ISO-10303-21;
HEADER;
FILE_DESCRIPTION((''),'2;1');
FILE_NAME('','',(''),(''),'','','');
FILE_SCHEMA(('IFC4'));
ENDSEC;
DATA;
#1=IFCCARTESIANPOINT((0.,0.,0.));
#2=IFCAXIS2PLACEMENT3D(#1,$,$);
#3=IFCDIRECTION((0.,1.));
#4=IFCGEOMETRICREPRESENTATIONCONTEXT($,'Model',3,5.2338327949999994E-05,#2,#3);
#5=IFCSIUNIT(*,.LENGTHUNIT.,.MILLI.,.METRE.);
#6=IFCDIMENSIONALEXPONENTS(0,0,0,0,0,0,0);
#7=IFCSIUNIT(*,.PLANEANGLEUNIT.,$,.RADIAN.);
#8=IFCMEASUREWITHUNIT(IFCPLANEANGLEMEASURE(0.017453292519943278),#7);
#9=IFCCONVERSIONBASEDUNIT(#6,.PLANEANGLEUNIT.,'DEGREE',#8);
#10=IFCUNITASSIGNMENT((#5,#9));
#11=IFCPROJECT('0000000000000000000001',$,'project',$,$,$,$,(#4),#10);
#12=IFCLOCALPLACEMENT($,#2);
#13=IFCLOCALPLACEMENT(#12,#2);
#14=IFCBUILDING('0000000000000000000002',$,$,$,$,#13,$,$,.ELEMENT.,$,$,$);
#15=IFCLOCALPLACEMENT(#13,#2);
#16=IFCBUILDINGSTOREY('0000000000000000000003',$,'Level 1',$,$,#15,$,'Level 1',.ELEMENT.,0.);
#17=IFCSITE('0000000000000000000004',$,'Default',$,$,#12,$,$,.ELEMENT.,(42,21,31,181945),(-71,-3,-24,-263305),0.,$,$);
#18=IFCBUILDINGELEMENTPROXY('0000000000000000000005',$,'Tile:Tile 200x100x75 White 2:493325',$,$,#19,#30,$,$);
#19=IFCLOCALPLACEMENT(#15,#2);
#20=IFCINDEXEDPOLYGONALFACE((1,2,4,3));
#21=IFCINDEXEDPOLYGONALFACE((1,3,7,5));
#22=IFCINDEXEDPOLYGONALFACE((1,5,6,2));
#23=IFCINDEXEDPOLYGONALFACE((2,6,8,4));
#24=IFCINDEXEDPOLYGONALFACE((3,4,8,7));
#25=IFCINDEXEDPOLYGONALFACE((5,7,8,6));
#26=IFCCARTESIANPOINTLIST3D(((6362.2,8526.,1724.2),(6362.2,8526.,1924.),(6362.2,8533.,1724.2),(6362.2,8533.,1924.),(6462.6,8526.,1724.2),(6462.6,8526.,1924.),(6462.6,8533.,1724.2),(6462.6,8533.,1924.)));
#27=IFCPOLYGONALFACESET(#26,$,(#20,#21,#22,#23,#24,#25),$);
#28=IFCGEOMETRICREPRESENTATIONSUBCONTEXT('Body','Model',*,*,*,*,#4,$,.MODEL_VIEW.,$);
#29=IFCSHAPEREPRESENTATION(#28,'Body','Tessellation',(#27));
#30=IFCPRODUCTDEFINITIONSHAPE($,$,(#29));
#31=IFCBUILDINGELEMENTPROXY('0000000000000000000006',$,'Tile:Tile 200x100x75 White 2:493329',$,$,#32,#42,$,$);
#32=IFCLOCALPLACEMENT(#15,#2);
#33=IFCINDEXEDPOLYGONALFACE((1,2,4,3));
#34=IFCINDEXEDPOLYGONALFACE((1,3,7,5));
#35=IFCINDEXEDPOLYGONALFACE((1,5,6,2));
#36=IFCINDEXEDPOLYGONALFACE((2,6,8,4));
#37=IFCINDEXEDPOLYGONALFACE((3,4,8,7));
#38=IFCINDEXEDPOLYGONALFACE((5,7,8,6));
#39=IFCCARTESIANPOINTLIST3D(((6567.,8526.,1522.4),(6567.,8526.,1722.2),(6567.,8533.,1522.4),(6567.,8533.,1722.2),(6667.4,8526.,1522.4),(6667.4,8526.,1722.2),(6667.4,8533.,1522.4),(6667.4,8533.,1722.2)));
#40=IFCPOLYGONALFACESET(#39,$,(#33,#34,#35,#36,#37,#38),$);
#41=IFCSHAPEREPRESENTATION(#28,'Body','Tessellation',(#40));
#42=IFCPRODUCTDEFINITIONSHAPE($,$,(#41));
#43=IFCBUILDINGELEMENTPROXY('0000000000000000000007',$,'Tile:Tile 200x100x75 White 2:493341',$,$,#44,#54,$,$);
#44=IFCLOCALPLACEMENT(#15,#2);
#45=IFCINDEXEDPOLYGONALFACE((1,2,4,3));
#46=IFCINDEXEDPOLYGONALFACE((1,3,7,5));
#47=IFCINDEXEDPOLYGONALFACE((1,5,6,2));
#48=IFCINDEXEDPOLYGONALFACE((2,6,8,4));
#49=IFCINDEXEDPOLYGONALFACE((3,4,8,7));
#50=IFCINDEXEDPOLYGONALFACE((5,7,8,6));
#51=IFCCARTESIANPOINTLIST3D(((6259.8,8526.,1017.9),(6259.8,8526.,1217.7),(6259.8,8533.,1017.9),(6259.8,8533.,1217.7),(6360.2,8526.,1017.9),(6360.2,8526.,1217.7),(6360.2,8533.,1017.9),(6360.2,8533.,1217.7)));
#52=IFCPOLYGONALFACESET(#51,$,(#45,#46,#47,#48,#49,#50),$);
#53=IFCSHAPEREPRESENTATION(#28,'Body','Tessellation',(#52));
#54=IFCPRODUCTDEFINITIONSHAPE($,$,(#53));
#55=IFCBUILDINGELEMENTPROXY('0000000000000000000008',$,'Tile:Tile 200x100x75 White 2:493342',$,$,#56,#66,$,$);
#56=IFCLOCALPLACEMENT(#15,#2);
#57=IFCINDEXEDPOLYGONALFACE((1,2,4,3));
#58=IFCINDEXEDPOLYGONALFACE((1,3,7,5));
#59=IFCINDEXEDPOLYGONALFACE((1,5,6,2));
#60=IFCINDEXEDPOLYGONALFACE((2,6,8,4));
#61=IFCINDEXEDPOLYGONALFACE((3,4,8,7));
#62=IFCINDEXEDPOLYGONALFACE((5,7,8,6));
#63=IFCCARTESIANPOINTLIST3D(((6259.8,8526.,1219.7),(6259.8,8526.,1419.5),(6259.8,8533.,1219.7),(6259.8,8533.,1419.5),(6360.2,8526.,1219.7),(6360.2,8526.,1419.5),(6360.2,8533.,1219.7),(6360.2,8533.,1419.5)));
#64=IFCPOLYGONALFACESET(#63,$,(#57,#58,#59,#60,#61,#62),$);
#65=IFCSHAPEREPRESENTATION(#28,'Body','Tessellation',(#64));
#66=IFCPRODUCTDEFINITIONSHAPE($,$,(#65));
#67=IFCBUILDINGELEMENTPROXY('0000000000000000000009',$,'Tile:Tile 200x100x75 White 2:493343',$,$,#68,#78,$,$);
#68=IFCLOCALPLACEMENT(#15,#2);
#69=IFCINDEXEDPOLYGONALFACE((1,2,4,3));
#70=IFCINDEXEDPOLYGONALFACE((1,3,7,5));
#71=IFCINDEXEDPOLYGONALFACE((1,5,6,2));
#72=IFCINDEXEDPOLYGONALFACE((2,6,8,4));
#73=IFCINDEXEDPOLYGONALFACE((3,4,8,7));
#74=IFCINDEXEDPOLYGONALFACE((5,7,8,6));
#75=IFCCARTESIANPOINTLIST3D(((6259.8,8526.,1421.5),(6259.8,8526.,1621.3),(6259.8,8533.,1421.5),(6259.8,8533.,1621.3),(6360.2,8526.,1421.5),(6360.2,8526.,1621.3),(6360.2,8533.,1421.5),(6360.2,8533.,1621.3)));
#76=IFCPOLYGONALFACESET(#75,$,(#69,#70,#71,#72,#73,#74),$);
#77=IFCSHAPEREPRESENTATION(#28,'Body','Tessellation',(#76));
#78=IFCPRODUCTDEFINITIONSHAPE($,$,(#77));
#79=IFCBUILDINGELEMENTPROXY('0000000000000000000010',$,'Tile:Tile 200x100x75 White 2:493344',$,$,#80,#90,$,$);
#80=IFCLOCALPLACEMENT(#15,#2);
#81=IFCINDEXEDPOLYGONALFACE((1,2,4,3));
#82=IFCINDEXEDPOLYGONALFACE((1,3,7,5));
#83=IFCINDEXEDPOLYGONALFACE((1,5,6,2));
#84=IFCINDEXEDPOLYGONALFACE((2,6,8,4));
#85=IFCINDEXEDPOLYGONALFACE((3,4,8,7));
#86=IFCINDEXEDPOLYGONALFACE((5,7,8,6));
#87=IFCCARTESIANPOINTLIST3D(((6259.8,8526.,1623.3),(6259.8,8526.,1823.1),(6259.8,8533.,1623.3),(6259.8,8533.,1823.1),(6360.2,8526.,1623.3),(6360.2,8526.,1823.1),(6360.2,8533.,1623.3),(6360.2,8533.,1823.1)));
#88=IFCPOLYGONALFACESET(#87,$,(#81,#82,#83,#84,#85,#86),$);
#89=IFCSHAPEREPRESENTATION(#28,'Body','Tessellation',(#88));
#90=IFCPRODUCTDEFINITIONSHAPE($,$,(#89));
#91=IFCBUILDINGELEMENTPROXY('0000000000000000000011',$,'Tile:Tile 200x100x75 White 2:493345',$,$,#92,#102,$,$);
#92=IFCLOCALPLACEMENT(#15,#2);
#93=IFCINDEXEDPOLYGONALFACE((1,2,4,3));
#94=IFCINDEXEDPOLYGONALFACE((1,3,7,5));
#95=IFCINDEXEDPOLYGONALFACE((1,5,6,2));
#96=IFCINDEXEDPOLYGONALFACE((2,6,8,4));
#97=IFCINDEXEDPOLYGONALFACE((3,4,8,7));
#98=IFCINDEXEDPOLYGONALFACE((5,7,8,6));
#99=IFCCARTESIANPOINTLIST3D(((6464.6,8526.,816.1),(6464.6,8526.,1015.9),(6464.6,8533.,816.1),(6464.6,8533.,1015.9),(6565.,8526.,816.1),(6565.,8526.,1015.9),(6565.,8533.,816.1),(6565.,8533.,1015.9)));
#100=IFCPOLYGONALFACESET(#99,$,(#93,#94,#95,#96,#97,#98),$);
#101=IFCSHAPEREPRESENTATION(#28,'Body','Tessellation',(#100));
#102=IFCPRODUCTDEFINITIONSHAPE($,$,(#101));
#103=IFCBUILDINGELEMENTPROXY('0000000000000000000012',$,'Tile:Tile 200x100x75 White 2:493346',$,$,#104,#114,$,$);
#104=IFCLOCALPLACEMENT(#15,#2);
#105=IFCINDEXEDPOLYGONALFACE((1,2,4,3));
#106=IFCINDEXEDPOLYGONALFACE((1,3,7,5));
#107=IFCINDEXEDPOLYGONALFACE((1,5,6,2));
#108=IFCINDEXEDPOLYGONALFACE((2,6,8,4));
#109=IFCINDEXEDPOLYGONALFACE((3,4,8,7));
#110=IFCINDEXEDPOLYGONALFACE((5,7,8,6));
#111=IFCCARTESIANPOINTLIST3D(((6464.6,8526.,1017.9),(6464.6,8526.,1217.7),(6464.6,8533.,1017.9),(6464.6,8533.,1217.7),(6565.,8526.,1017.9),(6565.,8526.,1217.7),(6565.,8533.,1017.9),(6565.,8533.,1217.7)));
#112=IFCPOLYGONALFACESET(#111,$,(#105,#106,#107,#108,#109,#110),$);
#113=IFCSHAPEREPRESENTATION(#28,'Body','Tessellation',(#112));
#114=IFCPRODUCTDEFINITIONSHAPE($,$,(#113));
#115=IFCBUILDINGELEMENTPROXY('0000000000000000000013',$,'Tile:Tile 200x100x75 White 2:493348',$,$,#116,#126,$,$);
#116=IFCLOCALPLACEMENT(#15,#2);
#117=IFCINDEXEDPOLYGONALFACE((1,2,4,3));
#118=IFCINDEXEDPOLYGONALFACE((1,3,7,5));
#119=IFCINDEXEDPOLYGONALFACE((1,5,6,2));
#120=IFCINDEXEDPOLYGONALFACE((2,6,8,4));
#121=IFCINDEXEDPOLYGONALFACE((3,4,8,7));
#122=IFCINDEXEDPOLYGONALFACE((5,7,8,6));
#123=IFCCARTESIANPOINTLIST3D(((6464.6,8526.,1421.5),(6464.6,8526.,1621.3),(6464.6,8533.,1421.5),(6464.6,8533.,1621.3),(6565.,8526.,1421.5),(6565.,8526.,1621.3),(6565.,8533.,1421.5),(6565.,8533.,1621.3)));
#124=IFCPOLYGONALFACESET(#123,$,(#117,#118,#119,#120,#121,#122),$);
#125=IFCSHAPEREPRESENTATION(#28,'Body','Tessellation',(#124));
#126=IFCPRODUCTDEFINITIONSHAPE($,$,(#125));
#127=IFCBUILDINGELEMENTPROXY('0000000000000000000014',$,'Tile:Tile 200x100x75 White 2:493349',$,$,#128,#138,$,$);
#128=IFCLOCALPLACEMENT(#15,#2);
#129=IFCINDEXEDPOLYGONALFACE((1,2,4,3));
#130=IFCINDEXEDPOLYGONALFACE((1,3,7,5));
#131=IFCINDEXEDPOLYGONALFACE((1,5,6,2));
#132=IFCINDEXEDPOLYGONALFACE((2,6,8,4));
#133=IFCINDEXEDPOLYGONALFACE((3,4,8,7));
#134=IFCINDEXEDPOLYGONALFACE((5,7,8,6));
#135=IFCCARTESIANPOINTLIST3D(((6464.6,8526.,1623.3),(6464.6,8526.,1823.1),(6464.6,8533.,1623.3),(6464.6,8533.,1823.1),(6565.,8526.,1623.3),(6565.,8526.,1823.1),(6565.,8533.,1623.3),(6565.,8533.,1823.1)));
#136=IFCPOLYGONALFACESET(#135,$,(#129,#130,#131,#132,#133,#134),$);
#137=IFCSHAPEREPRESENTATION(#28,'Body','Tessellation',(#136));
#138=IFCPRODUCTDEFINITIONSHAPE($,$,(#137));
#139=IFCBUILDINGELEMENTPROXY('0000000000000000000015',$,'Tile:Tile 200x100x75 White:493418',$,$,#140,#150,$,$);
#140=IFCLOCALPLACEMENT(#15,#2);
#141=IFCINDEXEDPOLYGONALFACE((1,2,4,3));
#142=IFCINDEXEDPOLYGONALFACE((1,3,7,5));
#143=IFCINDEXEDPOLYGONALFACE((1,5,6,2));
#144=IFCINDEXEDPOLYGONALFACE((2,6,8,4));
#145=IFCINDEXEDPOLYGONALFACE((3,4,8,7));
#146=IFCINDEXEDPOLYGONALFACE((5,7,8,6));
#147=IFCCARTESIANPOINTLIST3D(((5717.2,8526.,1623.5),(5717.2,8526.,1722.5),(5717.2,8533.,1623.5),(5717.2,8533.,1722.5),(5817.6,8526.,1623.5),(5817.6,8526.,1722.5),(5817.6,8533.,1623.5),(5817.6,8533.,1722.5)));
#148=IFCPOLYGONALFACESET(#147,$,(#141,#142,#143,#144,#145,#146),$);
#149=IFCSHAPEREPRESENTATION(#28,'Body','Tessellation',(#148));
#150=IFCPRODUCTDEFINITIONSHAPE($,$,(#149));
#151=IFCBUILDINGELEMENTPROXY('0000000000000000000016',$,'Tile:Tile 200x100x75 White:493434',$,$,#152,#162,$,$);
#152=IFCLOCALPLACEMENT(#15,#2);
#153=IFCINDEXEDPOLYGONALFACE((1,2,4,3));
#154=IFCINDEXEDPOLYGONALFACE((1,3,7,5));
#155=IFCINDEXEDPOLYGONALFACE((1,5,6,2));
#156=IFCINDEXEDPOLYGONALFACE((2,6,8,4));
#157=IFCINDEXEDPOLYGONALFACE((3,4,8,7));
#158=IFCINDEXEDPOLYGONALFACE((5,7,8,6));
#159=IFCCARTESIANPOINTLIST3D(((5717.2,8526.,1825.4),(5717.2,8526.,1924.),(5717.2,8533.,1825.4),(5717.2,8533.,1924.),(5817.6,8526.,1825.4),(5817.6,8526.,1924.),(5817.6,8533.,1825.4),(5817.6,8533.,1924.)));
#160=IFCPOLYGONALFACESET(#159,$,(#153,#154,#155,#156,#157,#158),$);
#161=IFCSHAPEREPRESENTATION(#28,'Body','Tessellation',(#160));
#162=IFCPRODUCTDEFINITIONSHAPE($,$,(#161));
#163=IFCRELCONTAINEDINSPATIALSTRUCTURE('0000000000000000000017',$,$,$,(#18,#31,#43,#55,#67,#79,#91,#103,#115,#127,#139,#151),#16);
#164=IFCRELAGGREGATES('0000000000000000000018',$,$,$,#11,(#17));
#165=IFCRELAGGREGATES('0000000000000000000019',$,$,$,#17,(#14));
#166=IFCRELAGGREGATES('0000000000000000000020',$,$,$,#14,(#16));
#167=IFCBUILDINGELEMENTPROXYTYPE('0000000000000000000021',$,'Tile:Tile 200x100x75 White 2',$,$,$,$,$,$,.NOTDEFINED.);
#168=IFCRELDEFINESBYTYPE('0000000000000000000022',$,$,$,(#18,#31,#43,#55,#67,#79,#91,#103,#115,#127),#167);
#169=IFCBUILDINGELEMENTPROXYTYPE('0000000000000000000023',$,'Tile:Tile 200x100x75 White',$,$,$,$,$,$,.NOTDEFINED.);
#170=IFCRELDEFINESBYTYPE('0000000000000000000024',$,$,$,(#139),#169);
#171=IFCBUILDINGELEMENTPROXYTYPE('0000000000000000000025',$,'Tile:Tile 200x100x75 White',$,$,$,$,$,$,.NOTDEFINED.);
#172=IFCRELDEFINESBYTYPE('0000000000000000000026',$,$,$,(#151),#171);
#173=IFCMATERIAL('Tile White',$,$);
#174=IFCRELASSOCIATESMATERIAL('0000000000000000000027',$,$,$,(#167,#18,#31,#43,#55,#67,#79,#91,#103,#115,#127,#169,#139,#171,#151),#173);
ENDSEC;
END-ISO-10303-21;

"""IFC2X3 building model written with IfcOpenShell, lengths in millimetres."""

from ifc_helpers import new_model, entity, si_unit, converted_unit, direction, frame, frame_2d, origin, origin_2d_with_axis, place, context, subcontext, project, spatial, rectangle, extrude, source, transform, mapped, material, type_object, type_shapes, element, save


model = new_model("IFC2X3")

# Units and contexts
model_context = context("Model", 3, precision=5.2338327949999994e-05, world=origin(), true_north=direction((0.0, 1.0)))
body_context = subcontext(model_context, "Body", "Model", "MODEL_VIEW")
ifc_project = project(units=[si_unit("LENGTHUNIT", "METRE", prefix="MILLI"), converted_unit("PLANEANGLEUNIT", "DEGREE", entity("IfcPlaneAngleMeasure", 0.017453292519943278), si_unit("PLANEANGLEUNIT", "RADIAN"), dimensions=[0, 0, 0, 0, 0, 0, 0])], contexts=[model_context])

# Site, building, storey
site_placement = place(None, origin())
site = spatial("IfcSite", under=ifc_project, at=site_placement, Name="Default", CompositionType="ELEMENT", RefLatitude=(42, 21, 31, 181945), RefLongitude=(-71, -3, -24, -263305), RefElevation=0.0)
building_placement = place(site_placement, origin())
building = spatial("IfcBuilding", under=site, at=building_placement, CompositionType="ELEMENT")
storey_placement = place(building_placement, origin())
storey = spatial("IfcBuildingStorey", under=building, at=storey_placement, Name="Level 1", LongName="Level 1", CompositionType="ELEMENT", Elevation=0.0)

# Building element proxies
ifc_material_1 = material(Name="Tile White")
building_element_proxy_type_1 = type_object("IfcBuildingElementProxyType", Name="Tile:Tile 200x100x75 White 2", PredefinedType="NOTDEFINED", material=ifc_material_1)
shared_shape_1 = source(origin(), body_context, "Body", "SweptSolid", [
    extrude(rectangle(XDim=199.8, YDim=100.4, at=frame_2d((0.0, 0.0), x_axis=(1.0, 0.0))), frame((-50.2, -99.9, 0.0), z_axis=(0.0, 0.0, 1.0), x_axis=(0.0, -1.0, 0.0)), (0.0, 0.0, 1.0), 7.0),
])
type_shapes(building_element_proxy_type_1, [shared_shape_1])
for number, where, z_axis, x_axis, name in (
    (1, (6462.6, 8533.0, 1924.0), (0.0, -1.0, 0.0), (1.0, 0.0, 0.0), "Tile:Tile 200x100x75 White 2:493325"),
    (2, (6667.4, 8533.0, 1722.2), (0.0, -1.0, 0.0), (1.0, 0.0, 0.0), "Tile:Tile 200x100x75 White 2:493329"),
    (3, (6360.2, 8533.0, 1217.7), (0.0, -1.0, 0.0), (1.0, 0.0, 0.0), "Tile:Tile 200x100x75 White 2:493341"),
    (4, (6360.2, 8533.0, 1419.5), (0.0, -1.0, 0.0), (1.0, 0.0, 0.0), "Tile:Tile 200x100x75 White 2:493342"),
    (5, (6360.2, 8533.0, 1621.3), (0.0, -1.0, 0.0), (1.0, 0.0, 0.0), "Tile:Tile 200x100x75 White 2:493343"),
    (6, (6360.2, 8533.0, 1823.1), (0.0, -1.0, 0.0), (1.0, 0.0, 0.0), "Tile:Tile 200x100x75 White 2:493344"),
    (7, (6565.0, 8533.0, 1015.9), (0.0, -1.0, 0.0), (1.0, 0.0, 0.0), "Tile:Tile 200x100x75 White 2:493345"),
    (8, (6565.0, 8533.0, 1217.7), (0.0, -1.0, 0.0), (1.0, 0.0, 0.0), "Tile:Tile 200x100x75 White 2:493346"),
    (9, (6565.0, 8533.0, 1621.3), (0.0, -1.0, 0.0), (1.0, 0.0, 0.0), "Tile:Tile 200x100x75 White 2:493348"),
    (10, (6565.0, 8533.0, 1823.1), (0.0, -1.0, 0.0), (1.0, 0.0, 0.0), "Tile:Tile 200x100x75 White 2:493349"),
):
    element("IfcBuildingElementProxy", number, at=place(storey_placement, frame(where, z_axis=z_axis, x_axis=x_axis)), inside=storey, type_object=building_element_proxy_type_1, material=ifc_material_1, Name=name, context=body_context, shape_type="MappedRepresentation", body=[
        mapped(shared_shape_1, transform((0.0, 0.0, 0.0), scale=1.0)),
    ])
building_element_proxy_type_2 = type_object("IfcBuildingElementProxyType", Name="Tile:Tile 200x100x75 White", PredefinedType="NOTDEFINED", material=ifc_material_1)
shared_shape_2 = source(origin(), body_context, "Body", "SweptSolid", [
    extrude(rectangle(XDim=99.0, YDim=100.4, at=origin_2d_with_axis()), frame((-50.2, -49.5, 0.0), z_axis=(0.0, 0.0, 1.0), x_axis=(0.0, -1.0, 0.0)), (0.0, 0.0, 1.0), 7.0),
])
type_shapes(building_element_proxy_type_2, [shared_shape_2])
proxy_1_placement = place(storey_placement, frame((5817.6, 8533.0, 1722.5), z_axis=(0.0, -1.0, 0.0), x_axis=(1.0, 0.0, 0.0)))
element("IfcBuildingElementProxy", 11, at=proxy_1_placement, inside=storey, type_object=building_element_proxy_type_2, material=ifc_material_1, Name="Tile:Tile 200x100x75 White:493418", context=body_context, shape_type="MappedRepresentation", body=[
    mapped(shared_shape_2, transform((0.0, 0.0, 0.0), scale=1.0)),
])
building_element_proxy_type_3 = type_object("IfcBuildingElementProxyType", Name="Tile:Tile 200x100x75 White", PredefinedType="NOTDEFINED", material=ifc_material_1)
shared_shape_3 = source(origin(), body_context, "Body", "SweptSolid", [
    extrude(rectangle(XDim=98.6, YDim=100.4, at=origin_2d_with_axis()), frame((-50.2, -49.3, 0.0), z_axis=(0.0, 0.0, 1.0), x_axis=(0.0, -1.0, 0.0)), (0.0, 0.0, 1.0), 7.0),
])
type_shapes(building_element_proxy_type_3, [shared_shape_3])
proxy_2_placement = place(storey_placement, frame((5817.6, 8533.0, 1924.0), z_axis=(0.0, -1.0, 0.0), x_axis=(1.0, 0.0, 0.0)))
element("IfcBuildingElementProxy", 12, at=proxy_2_placement, inside=storey, type_object=building_element_proxy_type_3, material=ifc_material_1, Name="Tile:Tile 200x100x75 White:493434", context=body_context, shape_type="MappedRepresentation", body=[
    mapped(shared_shape_3, transform((0.0, 0.0, 0.0), scale=1.0)),
])

save(model, "model.ifc")
